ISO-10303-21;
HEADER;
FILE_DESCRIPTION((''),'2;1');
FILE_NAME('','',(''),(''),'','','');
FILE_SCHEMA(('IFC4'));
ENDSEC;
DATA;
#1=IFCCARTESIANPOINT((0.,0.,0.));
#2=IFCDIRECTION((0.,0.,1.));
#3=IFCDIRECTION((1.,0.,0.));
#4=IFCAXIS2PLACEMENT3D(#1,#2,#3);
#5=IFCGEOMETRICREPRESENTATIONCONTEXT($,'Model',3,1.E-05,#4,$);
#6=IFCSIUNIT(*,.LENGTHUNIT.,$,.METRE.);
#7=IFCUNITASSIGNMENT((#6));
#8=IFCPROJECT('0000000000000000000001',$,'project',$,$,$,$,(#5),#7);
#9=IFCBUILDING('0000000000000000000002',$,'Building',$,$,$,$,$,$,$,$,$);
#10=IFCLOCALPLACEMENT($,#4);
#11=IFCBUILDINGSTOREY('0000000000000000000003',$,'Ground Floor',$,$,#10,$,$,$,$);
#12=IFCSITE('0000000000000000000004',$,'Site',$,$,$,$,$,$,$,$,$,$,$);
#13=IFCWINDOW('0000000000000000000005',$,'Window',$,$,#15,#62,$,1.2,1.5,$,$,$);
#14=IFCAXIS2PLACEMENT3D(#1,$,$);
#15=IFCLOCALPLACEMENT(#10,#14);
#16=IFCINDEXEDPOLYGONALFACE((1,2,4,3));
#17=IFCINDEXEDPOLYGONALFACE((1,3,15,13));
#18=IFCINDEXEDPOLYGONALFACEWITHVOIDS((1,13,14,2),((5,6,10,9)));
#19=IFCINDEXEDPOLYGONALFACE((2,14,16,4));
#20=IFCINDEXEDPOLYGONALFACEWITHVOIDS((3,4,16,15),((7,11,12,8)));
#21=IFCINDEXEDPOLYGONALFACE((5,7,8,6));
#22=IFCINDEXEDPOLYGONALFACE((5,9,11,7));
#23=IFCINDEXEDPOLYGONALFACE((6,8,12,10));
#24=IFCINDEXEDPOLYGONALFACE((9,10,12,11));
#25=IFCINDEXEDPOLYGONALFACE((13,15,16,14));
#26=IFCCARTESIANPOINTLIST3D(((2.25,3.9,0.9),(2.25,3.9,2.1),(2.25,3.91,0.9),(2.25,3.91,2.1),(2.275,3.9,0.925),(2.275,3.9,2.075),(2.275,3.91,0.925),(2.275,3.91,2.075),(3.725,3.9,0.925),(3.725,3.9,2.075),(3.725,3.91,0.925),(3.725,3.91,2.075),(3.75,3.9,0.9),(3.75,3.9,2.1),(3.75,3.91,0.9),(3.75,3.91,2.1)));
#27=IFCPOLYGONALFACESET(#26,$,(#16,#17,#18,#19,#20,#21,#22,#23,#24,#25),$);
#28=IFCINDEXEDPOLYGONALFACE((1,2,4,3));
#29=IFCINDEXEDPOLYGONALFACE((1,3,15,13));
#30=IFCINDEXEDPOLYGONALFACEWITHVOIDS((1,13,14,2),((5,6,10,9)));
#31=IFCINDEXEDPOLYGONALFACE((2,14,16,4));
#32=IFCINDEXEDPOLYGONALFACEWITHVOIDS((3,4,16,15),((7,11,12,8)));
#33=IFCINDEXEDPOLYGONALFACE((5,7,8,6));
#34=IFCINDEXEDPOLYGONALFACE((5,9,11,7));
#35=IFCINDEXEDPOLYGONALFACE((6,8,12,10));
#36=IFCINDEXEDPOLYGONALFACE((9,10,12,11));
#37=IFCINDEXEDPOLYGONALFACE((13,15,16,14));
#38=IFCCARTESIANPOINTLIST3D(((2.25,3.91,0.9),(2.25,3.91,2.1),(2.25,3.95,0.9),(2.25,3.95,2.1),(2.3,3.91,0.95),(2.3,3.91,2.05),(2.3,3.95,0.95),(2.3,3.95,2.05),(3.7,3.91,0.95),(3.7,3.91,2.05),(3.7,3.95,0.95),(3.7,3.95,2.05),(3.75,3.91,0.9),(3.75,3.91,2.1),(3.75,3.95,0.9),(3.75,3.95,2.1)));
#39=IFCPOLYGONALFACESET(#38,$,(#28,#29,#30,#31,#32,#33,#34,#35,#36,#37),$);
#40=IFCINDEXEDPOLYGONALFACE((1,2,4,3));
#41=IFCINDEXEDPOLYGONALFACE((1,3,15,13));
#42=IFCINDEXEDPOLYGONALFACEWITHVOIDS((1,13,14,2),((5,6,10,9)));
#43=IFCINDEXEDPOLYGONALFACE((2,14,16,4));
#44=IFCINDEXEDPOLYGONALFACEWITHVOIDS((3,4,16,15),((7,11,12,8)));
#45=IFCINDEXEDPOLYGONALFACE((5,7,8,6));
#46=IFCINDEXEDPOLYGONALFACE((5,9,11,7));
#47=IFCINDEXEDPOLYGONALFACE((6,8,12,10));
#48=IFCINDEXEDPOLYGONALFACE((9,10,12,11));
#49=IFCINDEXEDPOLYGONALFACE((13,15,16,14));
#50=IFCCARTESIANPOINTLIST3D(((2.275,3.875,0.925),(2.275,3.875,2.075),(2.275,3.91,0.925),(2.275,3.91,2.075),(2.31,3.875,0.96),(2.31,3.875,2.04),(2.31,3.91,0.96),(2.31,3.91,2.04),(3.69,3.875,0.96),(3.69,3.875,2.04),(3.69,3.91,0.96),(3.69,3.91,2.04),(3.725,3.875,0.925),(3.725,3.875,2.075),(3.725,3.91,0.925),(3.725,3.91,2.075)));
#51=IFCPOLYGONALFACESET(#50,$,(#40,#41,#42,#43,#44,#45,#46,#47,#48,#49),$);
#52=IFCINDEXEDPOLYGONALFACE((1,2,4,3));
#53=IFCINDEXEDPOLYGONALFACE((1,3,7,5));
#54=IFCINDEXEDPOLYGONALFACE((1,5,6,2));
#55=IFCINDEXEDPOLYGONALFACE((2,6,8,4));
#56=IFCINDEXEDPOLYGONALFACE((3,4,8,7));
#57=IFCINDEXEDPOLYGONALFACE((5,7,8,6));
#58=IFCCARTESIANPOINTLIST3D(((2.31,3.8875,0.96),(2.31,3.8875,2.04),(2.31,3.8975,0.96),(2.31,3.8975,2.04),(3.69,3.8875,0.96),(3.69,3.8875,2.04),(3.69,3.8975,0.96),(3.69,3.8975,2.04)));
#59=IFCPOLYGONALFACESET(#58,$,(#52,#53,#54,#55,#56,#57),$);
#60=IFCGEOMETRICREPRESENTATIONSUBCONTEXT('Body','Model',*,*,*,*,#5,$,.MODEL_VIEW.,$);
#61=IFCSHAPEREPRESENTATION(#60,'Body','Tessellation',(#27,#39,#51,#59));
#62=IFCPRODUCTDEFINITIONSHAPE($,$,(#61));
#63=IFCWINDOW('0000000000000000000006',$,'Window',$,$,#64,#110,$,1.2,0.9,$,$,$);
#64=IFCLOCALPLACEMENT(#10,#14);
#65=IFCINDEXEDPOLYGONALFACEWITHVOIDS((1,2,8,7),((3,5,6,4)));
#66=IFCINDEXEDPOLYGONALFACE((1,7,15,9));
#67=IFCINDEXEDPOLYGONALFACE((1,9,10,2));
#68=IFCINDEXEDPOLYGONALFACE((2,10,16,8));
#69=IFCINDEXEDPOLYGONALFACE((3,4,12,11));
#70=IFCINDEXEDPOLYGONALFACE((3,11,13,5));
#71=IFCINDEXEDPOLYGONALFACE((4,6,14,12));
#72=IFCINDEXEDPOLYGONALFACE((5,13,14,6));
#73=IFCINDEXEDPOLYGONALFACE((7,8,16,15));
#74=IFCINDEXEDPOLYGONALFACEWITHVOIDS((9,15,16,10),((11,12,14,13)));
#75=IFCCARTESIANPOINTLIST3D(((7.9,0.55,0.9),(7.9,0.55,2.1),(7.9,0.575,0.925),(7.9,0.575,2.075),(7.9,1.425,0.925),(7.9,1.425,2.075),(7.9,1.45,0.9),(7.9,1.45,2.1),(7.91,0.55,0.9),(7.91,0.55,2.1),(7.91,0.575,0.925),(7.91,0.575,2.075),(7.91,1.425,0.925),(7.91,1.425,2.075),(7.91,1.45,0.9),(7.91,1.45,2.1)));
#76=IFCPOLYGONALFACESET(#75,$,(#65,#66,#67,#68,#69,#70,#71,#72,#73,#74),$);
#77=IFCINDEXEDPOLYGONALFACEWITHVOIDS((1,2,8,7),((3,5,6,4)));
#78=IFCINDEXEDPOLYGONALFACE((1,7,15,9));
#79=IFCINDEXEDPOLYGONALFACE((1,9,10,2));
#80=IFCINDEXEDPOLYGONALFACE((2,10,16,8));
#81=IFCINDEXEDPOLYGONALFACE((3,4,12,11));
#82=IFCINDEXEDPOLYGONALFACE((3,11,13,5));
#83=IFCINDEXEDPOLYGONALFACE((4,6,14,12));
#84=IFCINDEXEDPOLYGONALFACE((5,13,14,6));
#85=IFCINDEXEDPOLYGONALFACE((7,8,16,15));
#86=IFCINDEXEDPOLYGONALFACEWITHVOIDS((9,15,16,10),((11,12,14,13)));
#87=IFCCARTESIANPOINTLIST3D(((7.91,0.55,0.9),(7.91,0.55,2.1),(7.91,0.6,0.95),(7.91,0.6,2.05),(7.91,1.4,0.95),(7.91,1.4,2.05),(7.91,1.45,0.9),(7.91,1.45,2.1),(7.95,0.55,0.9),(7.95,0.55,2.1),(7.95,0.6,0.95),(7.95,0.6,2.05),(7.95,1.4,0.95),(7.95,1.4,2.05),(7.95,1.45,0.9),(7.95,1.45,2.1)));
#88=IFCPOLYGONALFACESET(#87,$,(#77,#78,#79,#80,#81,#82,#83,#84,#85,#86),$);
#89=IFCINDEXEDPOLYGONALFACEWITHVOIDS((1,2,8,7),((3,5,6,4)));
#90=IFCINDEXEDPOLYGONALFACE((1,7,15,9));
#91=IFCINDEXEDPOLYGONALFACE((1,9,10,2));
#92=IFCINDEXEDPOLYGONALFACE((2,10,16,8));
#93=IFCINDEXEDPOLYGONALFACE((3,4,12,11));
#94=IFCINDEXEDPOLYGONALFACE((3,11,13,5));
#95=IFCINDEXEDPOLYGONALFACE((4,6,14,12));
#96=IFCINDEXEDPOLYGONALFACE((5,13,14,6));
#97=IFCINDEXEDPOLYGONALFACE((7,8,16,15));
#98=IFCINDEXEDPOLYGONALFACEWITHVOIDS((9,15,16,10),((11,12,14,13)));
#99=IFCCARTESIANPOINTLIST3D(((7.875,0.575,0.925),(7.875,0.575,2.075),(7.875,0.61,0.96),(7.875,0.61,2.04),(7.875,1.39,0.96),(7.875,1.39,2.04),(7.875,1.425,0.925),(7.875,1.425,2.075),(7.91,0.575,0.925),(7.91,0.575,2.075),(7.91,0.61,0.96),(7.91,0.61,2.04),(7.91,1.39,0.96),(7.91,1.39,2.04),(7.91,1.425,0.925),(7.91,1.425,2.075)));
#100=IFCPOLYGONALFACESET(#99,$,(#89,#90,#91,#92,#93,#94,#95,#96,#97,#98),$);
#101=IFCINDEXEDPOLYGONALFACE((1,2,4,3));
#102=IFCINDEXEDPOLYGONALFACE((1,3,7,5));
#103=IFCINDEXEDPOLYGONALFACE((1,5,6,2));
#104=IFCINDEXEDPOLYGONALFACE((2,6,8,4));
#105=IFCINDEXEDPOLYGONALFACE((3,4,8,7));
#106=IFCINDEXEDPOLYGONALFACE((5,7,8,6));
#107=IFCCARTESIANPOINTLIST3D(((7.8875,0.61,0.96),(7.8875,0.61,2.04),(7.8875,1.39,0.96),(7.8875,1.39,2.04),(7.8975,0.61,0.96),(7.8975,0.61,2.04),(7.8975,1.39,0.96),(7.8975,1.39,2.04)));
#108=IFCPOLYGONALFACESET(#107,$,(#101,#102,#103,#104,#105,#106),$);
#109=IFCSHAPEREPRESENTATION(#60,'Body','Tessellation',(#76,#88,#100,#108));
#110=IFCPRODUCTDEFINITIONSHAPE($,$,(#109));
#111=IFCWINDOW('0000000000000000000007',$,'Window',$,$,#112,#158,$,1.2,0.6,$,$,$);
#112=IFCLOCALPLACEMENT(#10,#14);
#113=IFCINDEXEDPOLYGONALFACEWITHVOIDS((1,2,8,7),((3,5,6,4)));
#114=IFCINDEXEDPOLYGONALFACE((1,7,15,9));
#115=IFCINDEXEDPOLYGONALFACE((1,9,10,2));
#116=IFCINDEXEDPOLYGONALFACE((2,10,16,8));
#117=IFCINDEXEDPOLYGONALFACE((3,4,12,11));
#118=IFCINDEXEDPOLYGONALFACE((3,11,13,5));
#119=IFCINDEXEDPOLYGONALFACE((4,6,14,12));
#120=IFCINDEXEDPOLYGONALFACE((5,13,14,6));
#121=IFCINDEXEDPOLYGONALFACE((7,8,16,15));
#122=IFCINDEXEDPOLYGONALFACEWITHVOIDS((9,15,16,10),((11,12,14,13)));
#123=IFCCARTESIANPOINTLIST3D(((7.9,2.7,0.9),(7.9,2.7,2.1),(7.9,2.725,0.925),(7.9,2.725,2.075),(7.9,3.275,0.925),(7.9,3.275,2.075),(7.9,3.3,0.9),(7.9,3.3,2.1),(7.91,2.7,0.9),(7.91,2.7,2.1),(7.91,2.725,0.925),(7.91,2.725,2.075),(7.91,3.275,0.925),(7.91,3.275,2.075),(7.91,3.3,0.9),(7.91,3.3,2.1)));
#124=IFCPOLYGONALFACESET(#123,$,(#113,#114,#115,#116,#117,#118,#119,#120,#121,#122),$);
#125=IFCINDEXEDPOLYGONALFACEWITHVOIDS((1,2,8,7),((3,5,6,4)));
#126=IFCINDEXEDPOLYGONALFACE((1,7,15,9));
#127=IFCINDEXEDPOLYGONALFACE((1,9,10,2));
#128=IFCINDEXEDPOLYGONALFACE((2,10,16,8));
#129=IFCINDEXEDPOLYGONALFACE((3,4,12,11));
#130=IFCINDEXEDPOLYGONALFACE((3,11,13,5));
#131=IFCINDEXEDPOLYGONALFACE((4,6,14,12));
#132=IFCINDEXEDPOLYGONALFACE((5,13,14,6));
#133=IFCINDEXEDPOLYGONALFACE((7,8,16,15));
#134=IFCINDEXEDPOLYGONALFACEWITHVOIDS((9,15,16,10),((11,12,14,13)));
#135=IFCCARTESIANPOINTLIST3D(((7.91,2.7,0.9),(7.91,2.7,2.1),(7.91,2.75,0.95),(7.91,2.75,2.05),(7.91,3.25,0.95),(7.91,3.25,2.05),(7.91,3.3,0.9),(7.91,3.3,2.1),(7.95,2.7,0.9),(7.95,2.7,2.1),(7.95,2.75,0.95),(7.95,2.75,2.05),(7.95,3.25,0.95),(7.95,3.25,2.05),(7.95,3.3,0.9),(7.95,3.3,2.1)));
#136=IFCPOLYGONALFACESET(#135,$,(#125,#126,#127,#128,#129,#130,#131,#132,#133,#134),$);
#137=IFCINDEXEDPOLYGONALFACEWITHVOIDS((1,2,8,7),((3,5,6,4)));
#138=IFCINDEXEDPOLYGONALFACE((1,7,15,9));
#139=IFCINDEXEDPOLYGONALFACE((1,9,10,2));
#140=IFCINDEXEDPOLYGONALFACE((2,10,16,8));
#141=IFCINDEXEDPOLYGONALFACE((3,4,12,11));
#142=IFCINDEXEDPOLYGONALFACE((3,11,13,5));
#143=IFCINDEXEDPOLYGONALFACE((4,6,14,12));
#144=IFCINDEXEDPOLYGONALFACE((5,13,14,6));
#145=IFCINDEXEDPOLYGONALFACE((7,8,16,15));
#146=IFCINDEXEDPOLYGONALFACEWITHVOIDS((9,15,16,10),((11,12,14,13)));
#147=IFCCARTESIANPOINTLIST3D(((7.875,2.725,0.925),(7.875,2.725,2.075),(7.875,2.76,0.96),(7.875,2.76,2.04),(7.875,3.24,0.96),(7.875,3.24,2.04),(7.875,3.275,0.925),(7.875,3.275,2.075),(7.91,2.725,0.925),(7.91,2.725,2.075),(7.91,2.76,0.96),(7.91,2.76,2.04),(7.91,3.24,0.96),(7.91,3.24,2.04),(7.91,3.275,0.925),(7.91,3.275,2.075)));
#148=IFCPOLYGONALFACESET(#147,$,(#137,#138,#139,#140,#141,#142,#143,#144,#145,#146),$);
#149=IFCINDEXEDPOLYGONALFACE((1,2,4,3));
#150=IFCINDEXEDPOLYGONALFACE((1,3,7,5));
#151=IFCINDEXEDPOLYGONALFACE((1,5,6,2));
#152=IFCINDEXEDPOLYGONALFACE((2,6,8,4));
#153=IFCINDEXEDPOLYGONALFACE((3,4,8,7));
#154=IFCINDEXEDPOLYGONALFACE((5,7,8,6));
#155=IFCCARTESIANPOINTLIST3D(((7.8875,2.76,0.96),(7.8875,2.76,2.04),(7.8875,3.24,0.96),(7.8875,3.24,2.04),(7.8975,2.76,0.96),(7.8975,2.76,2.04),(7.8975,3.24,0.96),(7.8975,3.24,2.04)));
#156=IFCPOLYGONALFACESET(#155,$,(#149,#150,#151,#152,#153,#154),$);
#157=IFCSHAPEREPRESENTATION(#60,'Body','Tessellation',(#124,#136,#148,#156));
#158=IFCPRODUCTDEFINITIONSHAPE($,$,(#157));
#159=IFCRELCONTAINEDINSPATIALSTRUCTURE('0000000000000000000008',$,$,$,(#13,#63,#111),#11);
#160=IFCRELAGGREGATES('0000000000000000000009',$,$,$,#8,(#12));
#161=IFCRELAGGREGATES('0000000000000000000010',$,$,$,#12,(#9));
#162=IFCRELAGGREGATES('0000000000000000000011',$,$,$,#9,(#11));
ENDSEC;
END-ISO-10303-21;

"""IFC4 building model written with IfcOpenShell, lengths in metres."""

from ifc_helpers import new_model, si_unit, frame, origin_with_axes, place, context, subcontext, project, spatial, line, indexed_curve, outline, extrude, element, save


model = new_model("IFC4")

# Units and contexts
model_context = context("Model", 3, precision=1e-05, world=origin_with_axes())
body_context = subcontext(model_context, "Body", "Model", "MODEL_VIEW")
ifc_project = project(units=[si_unit("LENGTHUNIT", "METRE")], contexts=[model_context])

# Site, building, storey
site = spatial("IfcSite", under=ifc_project, Name="Site")
building = spatial("IfcBuilding", under=site, Name="Building")
storey_placement = place(None, origin_with_axes())
storey = spatial("IfcBuildingStorey", under=building, at=storey_placement, Name="Ground Floor")

# Windows
for number, where, z_axis, x_axis, name in (
    (1, (3.75, 4.0, 0.9), (0.0, 0.0, 1.0), (-1.0, 0.0, 0.0), "Window"),
):
    element("IfcWindow", number, at=place(storey_placement, frame(where, z_axis=z_axis, x_axis=x_axis)), inside=storey, Name=name, OverallHeight=1.2, OverallWidth=1.5, context=body_context, shape_type="SweptSolid", body=[
        extrude(outline(indexed_curve([(0.0, 0.0), (1.5, 0.0), (1.5, 1.2), (0.0, 1.2)], segments=[line(1, 2, 3, 4, 1)]), holes=[indexed_curve([(0.025, 0.025), (1.475, 0.025), (1.475, 1.175), (0.025, 1.175)], segments=[line(1, 2, 3, 4, 1)])]), frame((0.0, 0.09, 0.0), z_axis=(0.0, -1.0, 0.0), x_axis=(1.0, 0.0, 0.0)), (0.0, 0.0, -1.0), 0.01),
        extrude(outline(indexed_curve([(0.0, 0.0), (1.5, 0.0), (1.5, 1.2), (0.0, 1.2)], segments=[line(1, 2, 3, 4, 1)]), holes=[indexed_curve([(0.05, 0.05), (1.45, 0.05), (1.45, 1.15), (0.05, 1.15)], segments=[line(1, 2, 3, 4, 1)])]), frame((0.0, 0.05, 0.0), z_axis=(0.0, -1.0, 0.0), x_axis=(1.0, 0.0, 0.0)), (0.0, 0.0, -1.0), 0.04),
        extrude(outline(indexed_curve([(0.0, 0.0), (1.45, 0.0), (1.45, 1.15), (0.0, 1.15)], segments=[line(1, 2, 3, 4, 1)]), holes=[indexed_curve([(0.035, 0.035), (1.415, 0.035), (1.415, 1.115), (0.035, 1.115)], segments=[line(1, 2, 3, 4, 1)])]), frame((0.025, 0.09, 0.025), z_axis=(0.0, -1.0, 0.0), x_axis=(1.0, 0.0, 0.0)), (0.0, 0.0, -1.0), 0.035),
        extrude(outline(indexed_curve([(0.035, 0.035), (1.415, 0.035), (1.415, 1.115), (0.035, 1.115)], segments=[line(1, 2, 3, 4, 1)])), frame((0.025, 0.1025, 0.025), z_axis=(0.0, -1.0, 0.0), x_axis=(1.0, 0.0, 0.0)), (0.0, 0.0, -1.0), 0.01),
    ])
window_1_placement = place(storey_placement, frame((8.0, 0.55, 0.9), z_axis=(0.0, 0.0, 1.0), x_axis=(0.0, 1.0, 0.0)))
element("IfcWindow", 2, at=window_1_placement, inside=storey, Name="Window", OverallHeight=1.2, OverallWidth=0.9, context=body_context, shape_type="SweptSolid", body=[
    extrude(outline(indexed_curve([(0.0, 0.0), (0.9, 0.0), (0.9, 1.2), (0.0, 1.2)], segments=[line(1, 2, 3, 4, 1)]), holes=[indexed_curve([(0.025, 0.025), (0.875, 0.025), (0.875, 1.175), (0.025, 1.175)], segments=[line(1, 2, 3, 4, 1)])]), frame((0.0, 0.09, 0.0), z_axis=(0.0, -1.0, 0.0), x_axis=(1.0, 0.0, 0.0)), (0.0, 0.0, -1.0), 0.01),
    extrude(outline(indexed_curve([(0.0, 0.0), (0.9, 0.0), (0.9, 1.2), (0.0, 1.2)], segments=[line(1, 2, 3, 4, 1)]), holes=[indexed_curve([(0.05, 0.05), (0.85, 0.05), (0.85, 1.15), (0.05, 1.15)], segments=[line(1, 2, 3, 4, 1)])]), frame((0.0, 0.05, 0.0), z_axis=(0.0, -1.0, 0.0), x_axis=(1.0, 0.0, 0.0)), (0.0, 0.0, -1.0), 0.04),
    extrude(outline(indexed_curve([(0.0, 0.0), (0.85, 0.0), (0.85, 1.15), (0.0, 1.15)], segments=[line(1, 2, 3, 4, 1)]), holes=[indexed_curve([(0.035, 0.035), (0.815, 0.035), (0.815, 1.115), (0.035, 1.115)], segments=[line(1, 2, 3, 4, 1)])]), frame((0.025, 0.09, 0.025), z_axis=(0.0, -1.0, 0.0), x_axis=(1.0, 0.0, 0.0)), (0.0, 0.0, -1.0), 0.035),
    extrude(outline(indexed_curve([(0.035, 0.035), (0.815, 0.035), (0.815, 1.115), (0.035, 1.115)], segments=[line(1, 2, 3, 4, 1)])), frame((0.025, 0.1025, 0.025), z_axis=(0.0, -1.0, 0.0), x_axis=(1.0, 0.0, 0.0)), (0.0, 0.0, -1.0), 0.01),
])
window_2_placement = place(storey_placement, frame((8.0, 2.7, 0.9), z_axis=(0.0, 0.0, 1.0), x_axis=(0.0, 1.0, 0.0)))
element("IfcWindow", 3, at=window_2_placement, inside=storey, Name="Window", OverallHeight=1.2, OverallWidth=0.6, context=body_context, shape_type="SweptSolid", body=[
    extrude(outline(indexed_curve([(0.0, 0.0), (0.6, 0.0), (0.6, 1.2), (0.0, 1.2)], segments=[line(1, 2, 3, 4, 1)]), holes=[indexed_curve([(0.025, 0.025), (0.575, 0.025), (0.575, 1.175), (0.025, 1.175)], segments=[line(1, 2, 3, 4, 1)])]), frame((0.0, 0.09, 0.0), z_axis=(0.0, -1.0, 0.0), x_axis=(1.0, 0.0, 0.0)), (0.0, 0.0, -1.0), 0.01),
    extrude(outline(indexed_curve([(0.0, 0.0), (0.6, 0.0), (0.6, 1.2), (0.0, 1.2)], segments=[line(1, 2, 3, 4, 1)]), holes=[indexed_curve([(0.05, 0.05), (0.55, 0.05), (0.55, 1.15), (0.05, 1.15)], segments=[line(1, 2, 3, 4, 1)])]), frame((0.0, 0.05, 0.0), z_axis=(0.0, -1.0, 0.0), x_axis=(1.0, 0.0, 0.0)), (0.0, 0.0, -1.0), 0.04),
    extrude(outline(indexed_curve([(0.0, 0.0), (0.55, 0.0), (0.55, 1.15), (0.0, 1.15)], segments=[line(1, 2, 3, 4, 1)]), holes=[indexed_curve([(0.035, 0.035), (0.515, 0.035), (0.515, 1.115), (0.035, 1.115)], segments=[line(1, 2, 3, 4, 1)])]), frame((0.025, 0.09, 0.025), z_axis=(0.0, -1.0, 0.0), x_axis=(1.0, 0.0, 0.0)), (0.0, 0.0, -1.0), 0.035),
    extrude(outline(indexed_curve([(0.035, 0.035), (0.515, 0.035), (0.515, 1.115), (0.035, 1.115)], segments=[line(1, 2, 3, 4, 1)])), frame((0.025, 0.1025, 0.025), z_axis=(0.0, -1.0, 0.0), x_axis=(1.0, 0.0, 0.0)), (0.0, 0.0, -1.0), 0.01),
])

save(model, "model.ifc")
